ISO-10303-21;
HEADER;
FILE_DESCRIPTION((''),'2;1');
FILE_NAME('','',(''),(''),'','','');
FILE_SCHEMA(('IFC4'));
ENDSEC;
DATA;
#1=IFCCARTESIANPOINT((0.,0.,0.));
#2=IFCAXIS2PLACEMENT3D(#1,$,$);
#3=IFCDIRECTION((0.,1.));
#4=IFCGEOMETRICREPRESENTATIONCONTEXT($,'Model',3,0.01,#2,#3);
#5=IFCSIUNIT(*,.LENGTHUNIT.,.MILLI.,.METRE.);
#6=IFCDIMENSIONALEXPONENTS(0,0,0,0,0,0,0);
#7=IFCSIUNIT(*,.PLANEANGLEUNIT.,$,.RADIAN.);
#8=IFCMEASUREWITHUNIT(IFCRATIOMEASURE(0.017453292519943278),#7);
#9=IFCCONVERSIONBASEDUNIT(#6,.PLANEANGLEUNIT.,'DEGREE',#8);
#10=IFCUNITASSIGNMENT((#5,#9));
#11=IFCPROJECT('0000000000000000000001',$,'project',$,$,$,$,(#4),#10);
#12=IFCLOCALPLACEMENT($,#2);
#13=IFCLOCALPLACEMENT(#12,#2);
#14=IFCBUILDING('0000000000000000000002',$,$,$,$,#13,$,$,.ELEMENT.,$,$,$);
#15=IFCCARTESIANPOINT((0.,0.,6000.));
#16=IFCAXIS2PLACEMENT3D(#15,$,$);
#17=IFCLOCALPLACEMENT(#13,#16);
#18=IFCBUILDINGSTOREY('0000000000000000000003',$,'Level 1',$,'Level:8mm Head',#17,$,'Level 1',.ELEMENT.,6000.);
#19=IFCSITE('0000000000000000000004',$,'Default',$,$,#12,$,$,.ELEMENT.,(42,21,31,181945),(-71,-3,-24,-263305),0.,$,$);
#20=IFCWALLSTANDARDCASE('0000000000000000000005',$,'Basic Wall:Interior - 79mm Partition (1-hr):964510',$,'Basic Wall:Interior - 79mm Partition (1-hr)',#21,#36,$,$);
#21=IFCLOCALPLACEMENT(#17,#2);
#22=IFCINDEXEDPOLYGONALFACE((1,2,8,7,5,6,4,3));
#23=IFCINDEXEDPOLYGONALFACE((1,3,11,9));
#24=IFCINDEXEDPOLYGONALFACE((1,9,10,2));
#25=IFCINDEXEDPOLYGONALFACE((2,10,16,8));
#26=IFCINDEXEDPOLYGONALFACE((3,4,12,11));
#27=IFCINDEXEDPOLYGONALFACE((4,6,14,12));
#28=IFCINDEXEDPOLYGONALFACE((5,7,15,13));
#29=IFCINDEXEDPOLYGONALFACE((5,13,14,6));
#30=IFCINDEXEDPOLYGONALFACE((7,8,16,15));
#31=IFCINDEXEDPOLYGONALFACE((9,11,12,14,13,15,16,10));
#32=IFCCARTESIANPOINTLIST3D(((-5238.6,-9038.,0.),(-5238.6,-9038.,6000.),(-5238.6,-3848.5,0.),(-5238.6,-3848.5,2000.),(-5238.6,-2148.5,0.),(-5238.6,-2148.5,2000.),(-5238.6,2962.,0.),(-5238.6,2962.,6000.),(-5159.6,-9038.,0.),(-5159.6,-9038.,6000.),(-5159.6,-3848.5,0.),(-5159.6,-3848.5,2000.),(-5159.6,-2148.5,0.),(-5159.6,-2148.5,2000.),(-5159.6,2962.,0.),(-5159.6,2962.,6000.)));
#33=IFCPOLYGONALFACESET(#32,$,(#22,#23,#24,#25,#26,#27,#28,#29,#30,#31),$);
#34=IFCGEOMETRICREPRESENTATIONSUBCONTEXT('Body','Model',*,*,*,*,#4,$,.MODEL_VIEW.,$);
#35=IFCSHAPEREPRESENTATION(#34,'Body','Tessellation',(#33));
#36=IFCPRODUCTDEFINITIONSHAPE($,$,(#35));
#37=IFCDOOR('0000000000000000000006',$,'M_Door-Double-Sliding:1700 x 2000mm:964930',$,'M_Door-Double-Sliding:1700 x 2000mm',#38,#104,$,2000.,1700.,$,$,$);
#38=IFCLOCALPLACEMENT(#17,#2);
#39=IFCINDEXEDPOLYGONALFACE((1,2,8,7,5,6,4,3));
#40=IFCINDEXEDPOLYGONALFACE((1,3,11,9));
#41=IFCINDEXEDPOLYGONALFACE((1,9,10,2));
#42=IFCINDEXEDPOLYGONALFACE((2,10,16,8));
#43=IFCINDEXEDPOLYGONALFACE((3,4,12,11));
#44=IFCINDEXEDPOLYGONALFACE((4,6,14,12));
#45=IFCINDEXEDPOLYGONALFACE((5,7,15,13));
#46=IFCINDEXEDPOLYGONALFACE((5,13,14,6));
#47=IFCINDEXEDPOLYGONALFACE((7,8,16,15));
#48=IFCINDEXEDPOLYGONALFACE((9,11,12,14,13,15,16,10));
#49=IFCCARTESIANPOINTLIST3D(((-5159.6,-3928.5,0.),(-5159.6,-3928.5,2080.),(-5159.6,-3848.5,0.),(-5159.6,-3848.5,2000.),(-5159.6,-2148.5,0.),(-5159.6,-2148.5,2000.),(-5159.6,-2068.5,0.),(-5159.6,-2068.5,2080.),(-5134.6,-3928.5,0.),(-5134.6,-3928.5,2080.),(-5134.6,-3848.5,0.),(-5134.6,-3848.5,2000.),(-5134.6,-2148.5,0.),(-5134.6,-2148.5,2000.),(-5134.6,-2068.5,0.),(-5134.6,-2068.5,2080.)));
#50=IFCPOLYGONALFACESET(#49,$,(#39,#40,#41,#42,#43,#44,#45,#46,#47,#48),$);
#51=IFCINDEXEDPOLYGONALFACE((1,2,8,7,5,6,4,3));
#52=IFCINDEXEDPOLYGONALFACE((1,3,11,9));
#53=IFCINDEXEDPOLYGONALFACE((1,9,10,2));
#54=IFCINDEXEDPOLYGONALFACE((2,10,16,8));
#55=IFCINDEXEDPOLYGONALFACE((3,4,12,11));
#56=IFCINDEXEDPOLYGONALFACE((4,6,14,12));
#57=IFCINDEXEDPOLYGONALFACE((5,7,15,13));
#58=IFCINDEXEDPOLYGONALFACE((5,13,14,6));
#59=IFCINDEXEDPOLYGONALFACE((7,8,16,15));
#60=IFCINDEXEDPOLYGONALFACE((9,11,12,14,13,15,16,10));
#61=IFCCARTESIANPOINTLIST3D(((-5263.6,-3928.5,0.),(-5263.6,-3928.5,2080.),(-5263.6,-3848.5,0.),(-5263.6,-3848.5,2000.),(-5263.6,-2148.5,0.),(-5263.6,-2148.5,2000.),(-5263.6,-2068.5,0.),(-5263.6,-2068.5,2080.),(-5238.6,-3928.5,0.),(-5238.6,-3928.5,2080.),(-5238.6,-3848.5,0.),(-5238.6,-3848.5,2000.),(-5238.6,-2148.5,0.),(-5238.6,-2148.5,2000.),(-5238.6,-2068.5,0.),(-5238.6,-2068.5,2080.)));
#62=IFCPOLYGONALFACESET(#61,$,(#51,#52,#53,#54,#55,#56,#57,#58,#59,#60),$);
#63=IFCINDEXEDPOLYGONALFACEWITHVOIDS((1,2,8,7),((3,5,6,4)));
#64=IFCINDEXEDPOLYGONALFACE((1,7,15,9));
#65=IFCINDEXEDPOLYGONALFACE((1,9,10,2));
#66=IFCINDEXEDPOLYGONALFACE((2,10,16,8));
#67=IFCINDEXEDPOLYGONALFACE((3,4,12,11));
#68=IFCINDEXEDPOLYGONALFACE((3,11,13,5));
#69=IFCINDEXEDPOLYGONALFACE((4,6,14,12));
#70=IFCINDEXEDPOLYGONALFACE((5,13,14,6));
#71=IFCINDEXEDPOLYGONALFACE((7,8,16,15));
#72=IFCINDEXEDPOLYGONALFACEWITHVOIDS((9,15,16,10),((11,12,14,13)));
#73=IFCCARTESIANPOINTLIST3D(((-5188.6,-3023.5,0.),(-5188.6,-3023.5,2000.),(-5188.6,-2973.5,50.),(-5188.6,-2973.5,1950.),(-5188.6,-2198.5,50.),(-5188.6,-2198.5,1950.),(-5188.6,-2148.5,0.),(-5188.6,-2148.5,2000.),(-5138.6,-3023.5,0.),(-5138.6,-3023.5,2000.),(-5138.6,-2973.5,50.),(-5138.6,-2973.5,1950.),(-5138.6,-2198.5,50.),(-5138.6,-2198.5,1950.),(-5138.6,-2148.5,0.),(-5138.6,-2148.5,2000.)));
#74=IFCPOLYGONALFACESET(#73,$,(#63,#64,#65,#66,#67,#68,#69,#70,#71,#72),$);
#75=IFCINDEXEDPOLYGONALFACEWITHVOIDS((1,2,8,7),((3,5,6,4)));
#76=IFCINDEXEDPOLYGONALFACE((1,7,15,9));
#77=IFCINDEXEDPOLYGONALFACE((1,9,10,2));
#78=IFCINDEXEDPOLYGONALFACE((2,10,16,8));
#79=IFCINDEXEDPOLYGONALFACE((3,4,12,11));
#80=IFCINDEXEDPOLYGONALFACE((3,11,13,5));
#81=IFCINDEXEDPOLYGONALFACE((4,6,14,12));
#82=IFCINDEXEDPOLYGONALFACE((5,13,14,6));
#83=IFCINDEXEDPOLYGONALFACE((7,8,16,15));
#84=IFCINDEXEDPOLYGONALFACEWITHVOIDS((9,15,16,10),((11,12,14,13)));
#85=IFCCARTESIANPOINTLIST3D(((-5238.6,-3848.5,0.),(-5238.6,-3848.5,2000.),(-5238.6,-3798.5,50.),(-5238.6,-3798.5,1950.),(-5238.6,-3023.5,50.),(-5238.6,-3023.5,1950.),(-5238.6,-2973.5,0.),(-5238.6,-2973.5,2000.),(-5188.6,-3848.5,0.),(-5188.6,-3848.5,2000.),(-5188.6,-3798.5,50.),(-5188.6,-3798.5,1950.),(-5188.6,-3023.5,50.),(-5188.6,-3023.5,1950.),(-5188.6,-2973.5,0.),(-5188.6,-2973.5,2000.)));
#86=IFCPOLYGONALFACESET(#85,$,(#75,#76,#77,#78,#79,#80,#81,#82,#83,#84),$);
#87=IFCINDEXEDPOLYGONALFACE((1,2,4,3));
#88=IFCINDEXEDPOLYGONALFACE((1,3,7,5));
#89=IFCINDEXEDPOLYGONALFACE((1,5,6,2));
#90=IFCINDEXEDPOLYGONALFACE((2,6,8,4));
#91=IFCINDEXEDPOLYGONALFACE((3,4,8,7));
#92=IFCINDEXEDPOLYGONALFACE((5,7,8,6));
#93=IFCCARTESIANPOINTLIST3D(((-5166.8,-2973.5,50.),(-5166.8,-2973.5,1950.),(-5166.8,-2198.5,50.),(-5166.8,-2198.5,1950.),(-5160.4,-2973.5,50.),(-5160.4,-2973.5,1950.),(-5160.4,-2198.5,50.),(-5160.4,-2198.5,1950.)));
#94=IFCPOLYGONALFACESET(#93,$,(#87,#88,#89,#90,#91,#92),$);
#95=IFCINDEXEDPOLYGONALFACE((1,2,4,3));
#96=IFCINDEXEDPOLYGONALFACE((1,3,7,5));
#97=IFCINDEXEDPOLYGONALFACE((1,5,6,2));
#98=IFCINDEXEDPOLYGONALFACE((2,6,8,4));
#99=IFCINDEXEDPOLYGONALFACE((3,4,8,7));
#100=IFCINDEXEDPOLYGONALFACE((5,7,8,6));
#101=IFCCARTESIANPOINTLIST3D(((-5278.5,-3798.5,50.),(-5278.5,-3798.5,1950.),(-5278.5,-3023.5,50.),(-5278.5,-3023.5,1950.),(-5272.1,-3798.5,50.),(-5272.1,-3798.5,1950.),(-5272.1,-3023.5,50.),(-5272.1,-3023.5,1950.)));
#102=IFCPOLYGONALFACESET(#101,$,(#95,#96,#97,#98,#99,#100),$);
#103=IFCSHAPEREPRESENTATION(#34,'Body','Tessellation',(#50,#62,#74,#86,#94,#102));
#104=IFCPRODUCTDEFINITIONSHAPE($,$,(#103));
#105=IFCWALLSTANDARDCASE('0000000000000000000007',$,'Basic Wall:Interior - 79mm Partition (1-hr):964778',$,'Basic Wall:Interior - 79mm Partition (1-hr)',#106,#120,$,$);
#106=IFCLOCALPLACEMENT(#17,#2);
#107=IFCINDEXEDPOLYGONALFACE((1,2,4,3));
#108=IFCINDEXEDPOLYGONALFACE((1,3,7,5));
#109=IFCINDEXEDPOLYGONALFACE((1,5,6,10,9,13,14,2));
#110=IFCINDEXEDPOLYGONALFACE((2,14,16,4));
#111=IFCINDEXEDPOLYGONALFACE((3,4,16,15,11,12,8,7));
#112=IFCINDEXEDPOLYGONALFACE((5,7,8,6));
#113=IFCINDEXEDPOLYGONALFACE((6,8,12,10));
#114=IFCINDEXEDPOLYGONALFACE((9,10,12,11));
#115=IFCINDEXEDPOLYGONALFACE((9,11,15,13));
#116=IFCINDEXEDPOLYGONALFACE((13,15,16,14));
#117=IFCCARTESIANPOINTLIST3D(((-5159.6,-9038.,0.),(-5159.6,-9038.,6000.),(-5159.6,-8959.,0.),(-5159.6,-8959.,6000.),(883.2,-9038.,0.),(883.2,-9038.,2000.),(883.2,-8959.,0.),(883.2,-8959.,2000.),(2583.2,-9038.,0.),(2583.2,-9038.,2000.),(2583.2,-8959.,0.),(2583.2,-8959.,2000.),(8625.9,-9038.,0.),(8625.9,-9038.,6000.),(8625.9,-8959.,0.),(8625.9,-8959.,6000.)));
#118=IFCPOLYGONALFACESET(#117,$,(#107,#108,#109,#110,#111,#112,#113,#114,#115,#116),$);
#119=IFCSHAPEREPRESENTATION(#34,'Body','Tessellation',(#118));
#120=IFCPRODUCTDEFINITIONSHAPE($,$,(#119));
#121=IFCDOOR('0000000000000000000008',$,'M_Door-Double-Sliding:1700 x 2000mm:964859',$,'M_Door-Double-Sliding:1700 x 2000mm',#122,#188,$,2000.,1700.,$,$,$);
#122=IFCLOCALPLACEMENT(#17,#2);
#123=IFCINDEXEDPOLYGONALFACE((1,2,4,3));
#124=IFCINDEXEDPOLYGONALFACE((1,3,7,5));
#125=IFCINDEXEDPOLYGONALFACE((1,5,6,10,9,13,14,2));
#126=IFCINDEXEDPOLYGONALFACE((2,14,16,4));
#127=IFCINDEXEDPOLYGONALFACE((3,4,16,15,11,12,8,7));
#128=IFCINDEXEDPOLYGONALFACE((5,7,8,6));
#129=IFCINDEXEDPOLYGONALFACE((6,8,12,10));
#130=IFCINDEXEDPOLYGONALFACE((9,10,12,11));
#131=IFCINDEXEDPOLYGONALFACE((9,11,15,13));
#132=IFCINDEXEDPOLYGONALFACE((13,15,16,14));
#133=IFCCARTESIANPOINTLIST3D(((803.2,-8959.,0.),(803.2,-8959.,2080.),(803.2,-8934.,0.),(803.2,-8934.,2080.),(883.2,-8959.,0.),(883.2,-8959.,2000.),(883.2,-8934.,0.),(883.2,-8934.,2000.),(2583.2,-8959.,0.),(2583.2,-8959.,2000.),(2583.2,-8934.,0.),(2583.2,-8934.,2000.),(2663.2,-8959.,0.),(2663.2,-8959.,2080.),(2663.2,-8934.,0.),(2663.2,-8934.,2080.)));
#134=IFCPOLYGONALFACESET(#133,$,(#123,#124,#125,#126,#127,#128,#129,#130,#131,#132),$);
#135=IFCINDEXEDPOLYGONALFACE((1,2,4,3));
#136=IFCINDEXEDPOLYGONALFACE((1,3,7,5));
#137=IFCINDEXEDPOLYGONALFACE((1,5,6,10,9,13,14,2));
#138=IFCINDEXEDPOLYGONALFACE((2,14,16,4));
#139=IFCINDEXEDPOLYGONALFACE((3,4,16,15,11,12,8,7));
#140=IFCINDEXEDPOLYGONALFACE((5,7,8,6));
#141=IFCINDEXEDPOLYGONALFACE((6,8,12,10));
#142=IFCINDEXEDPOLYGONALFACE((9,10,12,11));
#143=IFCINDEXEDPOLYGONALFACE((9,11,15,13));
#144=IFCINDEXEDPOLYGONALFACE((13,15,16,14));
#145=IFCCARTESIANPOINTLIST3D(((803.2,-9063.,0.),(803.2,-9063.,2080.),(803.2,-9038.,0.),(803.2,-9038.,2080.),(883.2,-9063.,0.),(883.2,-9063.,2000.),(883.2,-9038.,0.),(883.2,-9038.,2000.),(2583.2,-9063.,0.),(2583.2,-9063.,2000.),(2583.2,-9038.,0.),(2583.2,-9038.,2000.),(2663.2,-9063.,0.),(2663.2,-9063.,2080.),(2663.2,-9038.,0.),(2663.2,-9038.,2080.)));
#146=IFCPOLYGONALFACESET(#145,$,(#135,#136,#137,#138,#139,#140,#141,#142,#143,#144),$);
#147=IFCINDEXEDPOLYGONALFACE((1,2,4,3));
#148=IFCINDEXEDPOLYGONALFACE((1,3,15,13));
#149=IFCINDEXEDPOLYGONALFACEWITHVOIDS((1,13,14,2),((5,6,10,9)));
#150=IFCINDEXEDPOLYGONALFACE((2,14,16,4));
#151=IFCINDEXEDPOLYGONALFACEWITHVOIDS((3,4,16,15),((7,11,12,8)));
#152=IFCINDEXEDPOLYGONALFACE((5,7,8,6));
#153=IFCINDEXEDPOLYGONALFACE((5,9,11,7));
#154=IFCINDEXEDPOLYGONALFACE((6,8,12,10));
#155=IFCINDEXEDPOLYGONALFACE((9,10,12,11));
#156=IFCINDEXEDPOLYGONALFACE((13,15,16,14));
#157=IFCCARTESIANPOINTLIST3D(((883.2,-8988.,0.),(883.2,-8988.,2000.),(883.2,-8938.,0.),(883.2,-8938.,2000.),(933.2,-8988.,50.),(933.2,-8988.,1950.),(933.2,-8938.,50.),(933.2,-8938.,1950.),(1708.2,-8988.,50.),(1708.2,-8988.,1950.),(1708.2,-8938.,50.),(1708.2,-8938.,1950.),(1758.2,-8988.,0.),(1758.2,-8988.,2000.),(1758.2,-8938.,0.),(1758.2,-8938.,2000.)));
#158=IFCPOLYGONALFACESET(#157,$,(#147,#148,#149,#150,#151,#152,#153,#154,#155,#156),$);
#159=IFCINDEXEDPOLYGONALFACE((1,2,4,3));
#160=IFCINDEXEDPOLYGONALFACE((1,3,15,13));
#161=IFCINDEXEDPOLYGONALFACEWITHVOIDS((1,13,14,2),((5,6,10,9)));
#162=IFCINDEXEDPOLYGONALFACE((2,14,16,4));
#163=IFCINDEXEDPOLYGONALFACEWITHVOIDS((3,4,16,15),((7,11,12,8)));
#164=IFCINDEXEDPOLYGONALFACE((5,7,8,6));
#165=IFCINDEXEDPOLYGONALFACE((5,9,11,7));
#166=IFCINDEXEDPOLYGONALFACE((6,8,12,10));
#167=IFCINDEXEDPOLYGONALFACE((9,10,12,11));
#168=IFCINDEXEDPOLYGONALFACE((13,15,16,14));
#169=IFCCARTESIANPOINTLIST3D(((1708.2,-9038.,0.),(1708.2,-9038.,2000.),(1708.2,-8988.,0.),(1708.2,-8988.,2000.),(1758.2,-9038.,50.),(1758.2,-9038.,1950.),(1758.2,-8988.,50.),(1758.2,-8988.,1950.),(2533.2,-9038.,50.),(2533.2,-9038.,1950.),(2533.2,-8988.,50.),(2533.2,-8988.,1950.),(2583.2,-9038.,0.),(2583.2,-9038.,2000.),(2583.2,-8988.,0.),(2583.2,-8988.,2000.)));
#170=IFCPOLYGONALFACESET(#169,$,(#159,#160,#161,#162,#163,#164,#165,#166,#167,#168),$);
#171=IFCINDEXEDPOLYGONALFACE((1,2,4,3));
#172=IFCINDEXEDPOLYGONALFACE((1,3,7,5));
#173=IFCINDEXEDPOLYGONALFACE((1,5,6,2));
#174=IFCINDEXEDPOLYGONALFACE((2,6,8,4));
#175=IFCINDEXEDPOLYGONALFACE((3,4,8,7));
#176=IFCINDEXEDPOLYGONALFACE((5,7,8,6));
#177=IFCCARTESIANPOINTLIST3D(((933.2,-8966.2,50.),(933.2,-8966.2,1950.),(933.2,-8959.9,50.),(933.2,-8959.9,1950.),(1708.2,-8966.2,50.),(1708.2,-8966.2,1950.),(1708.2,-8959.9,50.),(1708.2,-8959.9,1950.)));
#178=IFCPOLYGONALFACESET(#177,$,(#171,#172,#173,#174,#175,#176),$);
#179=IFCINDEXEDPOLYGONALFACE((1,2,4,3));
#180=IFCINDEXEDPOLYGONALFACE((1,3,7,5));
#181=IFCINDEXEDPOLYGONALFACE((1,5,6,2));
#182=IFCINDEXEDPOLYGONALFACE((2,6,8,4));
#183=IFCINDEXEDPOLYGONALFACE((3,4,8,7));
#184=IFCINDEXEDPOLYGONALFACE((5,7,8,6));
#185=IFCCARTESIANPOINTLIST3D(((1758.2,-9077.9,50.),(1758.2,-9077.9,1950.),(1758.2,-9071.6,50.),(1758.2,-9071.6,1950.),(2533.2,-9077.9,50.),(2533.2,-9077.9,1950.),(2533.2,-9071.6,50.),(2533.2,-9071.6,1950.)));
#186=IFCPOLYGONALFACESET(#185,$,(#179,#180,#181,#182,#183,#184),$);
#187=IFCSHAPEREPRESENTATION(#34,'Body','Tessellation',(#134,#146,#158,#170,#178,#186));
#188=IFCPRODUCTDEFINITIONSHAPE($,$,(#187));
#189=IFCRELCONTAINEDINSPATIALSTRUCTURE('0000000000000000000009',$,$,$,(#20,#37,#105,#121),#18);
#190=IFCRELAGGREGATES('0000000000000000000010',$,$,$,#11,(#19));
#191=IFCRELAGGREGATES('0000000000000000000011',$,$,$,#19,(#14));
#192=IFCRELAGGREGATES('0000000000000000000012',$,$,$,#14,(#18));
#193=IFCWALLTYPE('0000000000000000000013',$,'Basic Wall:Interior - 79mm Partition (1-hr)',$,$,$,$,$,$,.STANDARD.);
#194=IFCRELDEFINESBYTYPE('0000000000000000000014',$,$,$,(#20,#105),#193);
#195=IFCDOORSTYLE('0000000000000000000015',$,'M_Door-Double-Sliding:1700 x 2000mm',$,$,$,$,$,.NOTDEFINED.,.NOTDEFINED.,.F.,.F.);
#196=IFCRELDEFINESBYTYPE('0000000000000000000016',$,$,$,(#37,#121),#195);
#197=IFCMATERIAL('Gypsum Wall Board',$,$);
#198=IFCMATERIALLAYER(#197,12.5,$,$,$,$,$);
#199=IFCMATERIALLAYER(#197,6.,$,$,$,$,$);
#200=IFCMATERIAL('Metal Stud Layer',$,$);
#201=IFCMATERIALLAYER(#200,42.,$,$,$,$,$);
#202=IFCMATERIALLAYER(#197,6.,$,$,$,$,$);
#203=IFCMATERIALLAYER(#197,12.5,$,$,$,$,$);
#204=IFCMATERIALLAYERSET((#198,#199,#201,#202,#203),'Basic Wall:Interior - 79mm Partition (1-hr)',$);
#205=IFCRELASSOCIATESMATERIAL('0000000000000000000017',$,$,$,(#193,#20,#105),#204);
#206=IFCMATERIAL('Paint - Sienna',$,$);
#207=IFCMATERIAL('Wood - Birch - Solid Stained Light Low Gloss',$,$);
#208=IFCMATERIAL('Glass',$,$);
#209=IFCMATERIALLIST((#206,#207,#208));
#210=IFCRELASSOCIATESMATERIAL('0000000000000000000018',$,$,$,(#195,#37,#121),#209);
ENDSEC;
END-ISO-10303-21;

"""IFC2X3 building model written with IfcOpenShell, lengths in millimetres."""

from ifc_helpers import new_model, entity, si_unit, converted_unit, direction, frame, frame_2d, origin, origin_2d_with_axis, place, context, subcontext, project, spatial, polyline, rectangle, outline, extrude, source, transform, mapped, material, material_list, layer, layer_set, layer_usage, type_object, type_shapes, element, fill, save


model = new_model("IFC2X3")

# Units and contexts
model_context = context("Model", 3, precision=0.01, world=origin(), true_north=direction((0.0, 1.0)))
body_context = subcontext(model_context, "Body", "Model", "MODEL_VIEW")
ifc_project = project(units=[si_unit("LENGTHUNIT", "METRE", prefix="MILLI"), converted_unit("PLANEANGLEUNIT", "DEGREE", entity("IfcRatioMeasure", 0.017453292519943278), si_unit("PLANEANGLEUNIT", "RADIAN"), dimensions=[0, 0, 0, 0, 0, 0, 0])], contexts=[model_context])

# Site, building, storey
site_placement = place(None, origin())
site = spatial("IfcSite", under=ifc_project, at=site_placement, Name="Default", CompositionType="ELEMENT", RefLatitude=(42, 21, 31, 181945), RefLongitude=(-71, -3, -24, -263305), RefElevation=0.0)
building_placement = place(site_placement, origin())
building = spatial("IfcBuilding", under=site, at=building_placement, CompositionType="ELEMENT")
storey_placement = place(building_placement, frame((0.0, 0.0, 6000.0)))
storey = spatial("IfcBuildingStorey", under=building, at=storey_placement, Name="Level 1", ObjectType="Level:8mm Head", LongName="Level 1", CompositionType="ELEMENT", Elevation=6000.0)

# Shared definitions
ifc_material_1 = material(Name="Gypsum Wall Board")
ifc_layer_1 = layer(ifc_material_1, 12.5)
ifc_layer_2 = layer(ifc_material_1, 6.0)
ifc_material_2 = material(Name="Metal Stud Layer")
ifc_layer_3 = layer(ifc_material_2, 42.0)
ifc_layer_4 = layer(ifc_material_1, 6.0)
ifc_layer_5 = layer(ifc_material_1, 12.5)
ifc_layer_set_1 = layer_set([ifc_layer_1, ifc_layer_2, ifc_layer_3, ifc_layer_4, ifc_layer_5], Name="Basic Wall:Interior - 79mm Partition (1-hr)")
ifc_layer_usage_1 = layer_usage(ifc_layer_set_1, "AXIS2", "NEGATIVE", 39.5)
wall_type = type_object("IfcWallType", Name="Basic Wall:Interior - 79mm Partition (1-hr)", PredefinedType="STANDARD", material=ifc_layer_set_1)

# Walls, openings, doors
ifc_material_3 = material(Name="Paint - Sienna")
ifc_material_4 = material(Name="Wood - Birch - Solid Stained Light Low Gloss")
ifc_material_5 = material(Name="Glass")
ifc_material_list_1 = material_list([ifc_material_3, ifc_material_4, ifc_material_5])
door_style = type_object("IfcDoorStyle", Name="M_Door-Double-Sliding:1700 x 2000mm", ConstructionType="NOTDEFINED", OperationType="NOTDEFINED", ParameterTakesPrecedence=False, Sizeable=False, material=ifc_material_list_1)
shared_shape_1 = source(origin(), body_context, "Body", "SweptSolid", [
    extrude(outline(polyline([(-1020.0, -930.0), (1060.0, -930.0), (1060.0, 930.0), (-1020.0, 930.0), (-1020.0, 850.0), (980.0, 850.0), (980.0, -850.0), (-1020.0, -850.0), (-1020.0, -930.0)])), frame((850.0, -25.0, 1020.0), z_axis=(0.0, 1.0, 0.0), x_axis=(0.0, 0.0, 1.0)), (0.0, 0.0, 1.0), 25.0),
    extrude(outline(polyline([(-930.0, -1020.0), (-850.0, -1020.0), (-850.0, 980.0), (850.0, 980.0), (850.0, -1020.0), (930.0, -1020.0), (930.0, 1060.0), (-930.0, 1060.0), (-930.0, -1020.0)])), frame((850.0, 79.0, 1020.0), z_axis=(0.0, 1.0, 0.0), x_axis=(-1.0, 0.0, 0.0)), (0.0, 0.0, 1.0), 25.0),
    extrude(outline(polyline([(-437.5, -1000.0), (437.5, -1000.0), (437.5, 1000.0), (-437.5, 1000.0), (-437.5, -1000.0)]), holes=[polyline([(-387.5, -950.0), (-387.5, 950.0), (387.5, 950.0), (387.5, -950.0), (-387.5, -950.0)])]), frame((1262.5, -21.0, 1000.0), z_axis=(0.0, 1.0, 0.0), x_axis=(1.0, 0.0, 0.0)), (0.0, 0.0, 1.0), 50.0),
    extrude(outline(polyline([(-1000.0, -437.5), (1000.0, -437.5), (1000.0, 437.5), (-1000.0, 437.5), (-1000.0, -437.5)]), holes=[polyline([(-950.0, -387.5), (-950.0, 387.5), (950.0, 387.5), (950.0, -387.5), (-950.0, -387.5)])]), frame((437.5, 29.0, 1000.0), z_axis=(0.0, 1.0, 0.0), x_axis=(0.0, 0.0, -1.0)), (0.0, 0.0, 1.0), 50.0),
    extrude(rectangle(XDim=6.3, YDim=775.0, at=frame_2d((0.0, 0.0), x_axis=(1.0, 0.0))), frame((1262.5, 4.0, 50.0), z_axis=(0.0, 0.0, 1.0), x_axis=(0.0, -1.0, 0.0)), (0.0, 0.0, 1.0), 1900.0),
    extrude(rectangle(XDim=6.4, YDim=775.0, at=origin_2d_with_axis()), frame((437.5, 115.7, 50.0), z_axis=(0.0, 0.0, 1.0), x_axis=(0.0, 1.0, 0.0)), (0.0, 0.0, 1.0), 1900.0),
])
type_shapes(door_style, [shared_shape_1])
wall_1_placement = place(storey_placement, frame((-5199.1, 2962.0, 0.0), z_axis=(0.0, 0.0, 1.0), x_axis=(0.0, -1.0, 0.0)))
wall_1 = element("IfcWallStandardCase", 1, at=wall_1_placement, inside=storey, type_object=wall_type, material=ifc_layer_usage_1, Name="Basic Wall:Interior - 79mm Partition (1-hr):964510", ObjectType="Basic Wall:Interior - 79mm Partition (1-hr)", context=body_context, shape_type="SweptSolid", body=[
    extrude(rectangle(XDim=12000.0, YDim=79.0, at=frame_2d((6000.0, 0.0), x_axis=(1.0, 0.0))), origin(), (0.0, 0.0, 1.0), 6000.0),
])
opening_1_placement = place(wall_1_placement, frame((6810.5, 39.5, 0.0)))
opening_1 = element("IfcOpeningElement", 2, at=opening_1_placement, cuts=wall_1, ObjectType="Opening", context=body_context, shape_type="SweptSolid", body=[
    extrude(rectangle(XDim=2000.0, YDim=1700.0, at=frame_2d((1000.0, 850.0), x_axis=(-1.0, 0.0))), frame((0.0, 0.0, 0.0), z_axis=(0.0, -1.0, 0.0), x_axis=(0.0, 0.0, 1.0)), (0.0, 0.0, 1.0), 79.0),
])
door_1_placement = place(opening_1_placement, frame((0.0, 0.0, 0.0), z_axis=(0.0, 0.0, 1.0), x_axis=(-1.0, 0.0, 0.0)))
door_1 = element("IfcDoor", 3, at=door_1_placement, inside=storey, type_object=door_style, material=ifc_material_list_1, Name="M_Door-Double-Sliding:1700 x 2000mm:964930", ObjectType="M_Door-Double-Sliding:1700 x 2000mm", OverallHeight=2000.0, OverallWidth=1700.0, context=body_context, shape_type="MappedRepresentation", body=[
    mapped(shared_shape_1, transform((0.0, 0.0, 0.0), scale=1.0)),
])
fill(opening_1, door_1)
wall_2_placement = place(storey_placement, frame((-5159.6, -8998.5, 0.0)))
wall_2 = element("IfcWallStandardCase", 4, at=wall_2_placement, inside=storey, type_object=wall_type, material=ifc_layer_usage_1, Name="Basic Wall:Interior - 79mm Partition (1-hr):964778", ObjectType="Basic Wall:Interior - 79mm Partition (1-hr)", context=body_context, shape_type="SweptSolid", body=[
    extrude(rectangle(XDim=13785.5, YDim=79.0, at=frame_2d((6892.8, 0.0), x_axis=(1.0, 0.0))), origin(), (0.0, 0.0, 1.0), 6000.0),
])
opening_2_placement = place(wall_2_placement, frame((7742.8, 39.5, 0.0)))
opening_2 = element("IfcOpeningElement", 5, at=opening_2_placement, cuts=wall_2, ObjectType="Opening", context=body_context, shape_type="SweptSolid", body=[
    extrude(rectangle(XDim=2000.0, YDim=1700.0, at=frame_2d((1000.0, 850.0), x_axis=(-1.0, 0.0))), frame((0.0, 0.0, 0.0), z_axis=(0.0, -1.0, 0.0), x_axis=(0.0, 0.0, 1.0)), (0.0, 0.0, 1.0), 79.0),
])
door_2_placement = place(opening_2_placement, frame((0.0, 0.0, 0.0), z_axis=(0.0, 0.0, 1.0), x_axis=(-1.0, 0.0, 0.0)))
door_2 = element("IfcDoor", 6, at=door_2_placement, inside=storey, type_object=door_style, material=ifc_material_list_1, Name="M_Door-Double-Sliding:1700 x 2000mm:964859", ObjectType="M_Door-Double-Sliding:1700 x 2000mm", OverallHeight=2000.0, OverallWidth=1700.0, context=body_context, shape_type="MappedRepresentation", body=[
    mapped(shared_shape_1, transform((0.0, 0.0, 0.0), scale=1.0)),
])
fill(opening_2, door_2)

save(model, "model.ifc")
